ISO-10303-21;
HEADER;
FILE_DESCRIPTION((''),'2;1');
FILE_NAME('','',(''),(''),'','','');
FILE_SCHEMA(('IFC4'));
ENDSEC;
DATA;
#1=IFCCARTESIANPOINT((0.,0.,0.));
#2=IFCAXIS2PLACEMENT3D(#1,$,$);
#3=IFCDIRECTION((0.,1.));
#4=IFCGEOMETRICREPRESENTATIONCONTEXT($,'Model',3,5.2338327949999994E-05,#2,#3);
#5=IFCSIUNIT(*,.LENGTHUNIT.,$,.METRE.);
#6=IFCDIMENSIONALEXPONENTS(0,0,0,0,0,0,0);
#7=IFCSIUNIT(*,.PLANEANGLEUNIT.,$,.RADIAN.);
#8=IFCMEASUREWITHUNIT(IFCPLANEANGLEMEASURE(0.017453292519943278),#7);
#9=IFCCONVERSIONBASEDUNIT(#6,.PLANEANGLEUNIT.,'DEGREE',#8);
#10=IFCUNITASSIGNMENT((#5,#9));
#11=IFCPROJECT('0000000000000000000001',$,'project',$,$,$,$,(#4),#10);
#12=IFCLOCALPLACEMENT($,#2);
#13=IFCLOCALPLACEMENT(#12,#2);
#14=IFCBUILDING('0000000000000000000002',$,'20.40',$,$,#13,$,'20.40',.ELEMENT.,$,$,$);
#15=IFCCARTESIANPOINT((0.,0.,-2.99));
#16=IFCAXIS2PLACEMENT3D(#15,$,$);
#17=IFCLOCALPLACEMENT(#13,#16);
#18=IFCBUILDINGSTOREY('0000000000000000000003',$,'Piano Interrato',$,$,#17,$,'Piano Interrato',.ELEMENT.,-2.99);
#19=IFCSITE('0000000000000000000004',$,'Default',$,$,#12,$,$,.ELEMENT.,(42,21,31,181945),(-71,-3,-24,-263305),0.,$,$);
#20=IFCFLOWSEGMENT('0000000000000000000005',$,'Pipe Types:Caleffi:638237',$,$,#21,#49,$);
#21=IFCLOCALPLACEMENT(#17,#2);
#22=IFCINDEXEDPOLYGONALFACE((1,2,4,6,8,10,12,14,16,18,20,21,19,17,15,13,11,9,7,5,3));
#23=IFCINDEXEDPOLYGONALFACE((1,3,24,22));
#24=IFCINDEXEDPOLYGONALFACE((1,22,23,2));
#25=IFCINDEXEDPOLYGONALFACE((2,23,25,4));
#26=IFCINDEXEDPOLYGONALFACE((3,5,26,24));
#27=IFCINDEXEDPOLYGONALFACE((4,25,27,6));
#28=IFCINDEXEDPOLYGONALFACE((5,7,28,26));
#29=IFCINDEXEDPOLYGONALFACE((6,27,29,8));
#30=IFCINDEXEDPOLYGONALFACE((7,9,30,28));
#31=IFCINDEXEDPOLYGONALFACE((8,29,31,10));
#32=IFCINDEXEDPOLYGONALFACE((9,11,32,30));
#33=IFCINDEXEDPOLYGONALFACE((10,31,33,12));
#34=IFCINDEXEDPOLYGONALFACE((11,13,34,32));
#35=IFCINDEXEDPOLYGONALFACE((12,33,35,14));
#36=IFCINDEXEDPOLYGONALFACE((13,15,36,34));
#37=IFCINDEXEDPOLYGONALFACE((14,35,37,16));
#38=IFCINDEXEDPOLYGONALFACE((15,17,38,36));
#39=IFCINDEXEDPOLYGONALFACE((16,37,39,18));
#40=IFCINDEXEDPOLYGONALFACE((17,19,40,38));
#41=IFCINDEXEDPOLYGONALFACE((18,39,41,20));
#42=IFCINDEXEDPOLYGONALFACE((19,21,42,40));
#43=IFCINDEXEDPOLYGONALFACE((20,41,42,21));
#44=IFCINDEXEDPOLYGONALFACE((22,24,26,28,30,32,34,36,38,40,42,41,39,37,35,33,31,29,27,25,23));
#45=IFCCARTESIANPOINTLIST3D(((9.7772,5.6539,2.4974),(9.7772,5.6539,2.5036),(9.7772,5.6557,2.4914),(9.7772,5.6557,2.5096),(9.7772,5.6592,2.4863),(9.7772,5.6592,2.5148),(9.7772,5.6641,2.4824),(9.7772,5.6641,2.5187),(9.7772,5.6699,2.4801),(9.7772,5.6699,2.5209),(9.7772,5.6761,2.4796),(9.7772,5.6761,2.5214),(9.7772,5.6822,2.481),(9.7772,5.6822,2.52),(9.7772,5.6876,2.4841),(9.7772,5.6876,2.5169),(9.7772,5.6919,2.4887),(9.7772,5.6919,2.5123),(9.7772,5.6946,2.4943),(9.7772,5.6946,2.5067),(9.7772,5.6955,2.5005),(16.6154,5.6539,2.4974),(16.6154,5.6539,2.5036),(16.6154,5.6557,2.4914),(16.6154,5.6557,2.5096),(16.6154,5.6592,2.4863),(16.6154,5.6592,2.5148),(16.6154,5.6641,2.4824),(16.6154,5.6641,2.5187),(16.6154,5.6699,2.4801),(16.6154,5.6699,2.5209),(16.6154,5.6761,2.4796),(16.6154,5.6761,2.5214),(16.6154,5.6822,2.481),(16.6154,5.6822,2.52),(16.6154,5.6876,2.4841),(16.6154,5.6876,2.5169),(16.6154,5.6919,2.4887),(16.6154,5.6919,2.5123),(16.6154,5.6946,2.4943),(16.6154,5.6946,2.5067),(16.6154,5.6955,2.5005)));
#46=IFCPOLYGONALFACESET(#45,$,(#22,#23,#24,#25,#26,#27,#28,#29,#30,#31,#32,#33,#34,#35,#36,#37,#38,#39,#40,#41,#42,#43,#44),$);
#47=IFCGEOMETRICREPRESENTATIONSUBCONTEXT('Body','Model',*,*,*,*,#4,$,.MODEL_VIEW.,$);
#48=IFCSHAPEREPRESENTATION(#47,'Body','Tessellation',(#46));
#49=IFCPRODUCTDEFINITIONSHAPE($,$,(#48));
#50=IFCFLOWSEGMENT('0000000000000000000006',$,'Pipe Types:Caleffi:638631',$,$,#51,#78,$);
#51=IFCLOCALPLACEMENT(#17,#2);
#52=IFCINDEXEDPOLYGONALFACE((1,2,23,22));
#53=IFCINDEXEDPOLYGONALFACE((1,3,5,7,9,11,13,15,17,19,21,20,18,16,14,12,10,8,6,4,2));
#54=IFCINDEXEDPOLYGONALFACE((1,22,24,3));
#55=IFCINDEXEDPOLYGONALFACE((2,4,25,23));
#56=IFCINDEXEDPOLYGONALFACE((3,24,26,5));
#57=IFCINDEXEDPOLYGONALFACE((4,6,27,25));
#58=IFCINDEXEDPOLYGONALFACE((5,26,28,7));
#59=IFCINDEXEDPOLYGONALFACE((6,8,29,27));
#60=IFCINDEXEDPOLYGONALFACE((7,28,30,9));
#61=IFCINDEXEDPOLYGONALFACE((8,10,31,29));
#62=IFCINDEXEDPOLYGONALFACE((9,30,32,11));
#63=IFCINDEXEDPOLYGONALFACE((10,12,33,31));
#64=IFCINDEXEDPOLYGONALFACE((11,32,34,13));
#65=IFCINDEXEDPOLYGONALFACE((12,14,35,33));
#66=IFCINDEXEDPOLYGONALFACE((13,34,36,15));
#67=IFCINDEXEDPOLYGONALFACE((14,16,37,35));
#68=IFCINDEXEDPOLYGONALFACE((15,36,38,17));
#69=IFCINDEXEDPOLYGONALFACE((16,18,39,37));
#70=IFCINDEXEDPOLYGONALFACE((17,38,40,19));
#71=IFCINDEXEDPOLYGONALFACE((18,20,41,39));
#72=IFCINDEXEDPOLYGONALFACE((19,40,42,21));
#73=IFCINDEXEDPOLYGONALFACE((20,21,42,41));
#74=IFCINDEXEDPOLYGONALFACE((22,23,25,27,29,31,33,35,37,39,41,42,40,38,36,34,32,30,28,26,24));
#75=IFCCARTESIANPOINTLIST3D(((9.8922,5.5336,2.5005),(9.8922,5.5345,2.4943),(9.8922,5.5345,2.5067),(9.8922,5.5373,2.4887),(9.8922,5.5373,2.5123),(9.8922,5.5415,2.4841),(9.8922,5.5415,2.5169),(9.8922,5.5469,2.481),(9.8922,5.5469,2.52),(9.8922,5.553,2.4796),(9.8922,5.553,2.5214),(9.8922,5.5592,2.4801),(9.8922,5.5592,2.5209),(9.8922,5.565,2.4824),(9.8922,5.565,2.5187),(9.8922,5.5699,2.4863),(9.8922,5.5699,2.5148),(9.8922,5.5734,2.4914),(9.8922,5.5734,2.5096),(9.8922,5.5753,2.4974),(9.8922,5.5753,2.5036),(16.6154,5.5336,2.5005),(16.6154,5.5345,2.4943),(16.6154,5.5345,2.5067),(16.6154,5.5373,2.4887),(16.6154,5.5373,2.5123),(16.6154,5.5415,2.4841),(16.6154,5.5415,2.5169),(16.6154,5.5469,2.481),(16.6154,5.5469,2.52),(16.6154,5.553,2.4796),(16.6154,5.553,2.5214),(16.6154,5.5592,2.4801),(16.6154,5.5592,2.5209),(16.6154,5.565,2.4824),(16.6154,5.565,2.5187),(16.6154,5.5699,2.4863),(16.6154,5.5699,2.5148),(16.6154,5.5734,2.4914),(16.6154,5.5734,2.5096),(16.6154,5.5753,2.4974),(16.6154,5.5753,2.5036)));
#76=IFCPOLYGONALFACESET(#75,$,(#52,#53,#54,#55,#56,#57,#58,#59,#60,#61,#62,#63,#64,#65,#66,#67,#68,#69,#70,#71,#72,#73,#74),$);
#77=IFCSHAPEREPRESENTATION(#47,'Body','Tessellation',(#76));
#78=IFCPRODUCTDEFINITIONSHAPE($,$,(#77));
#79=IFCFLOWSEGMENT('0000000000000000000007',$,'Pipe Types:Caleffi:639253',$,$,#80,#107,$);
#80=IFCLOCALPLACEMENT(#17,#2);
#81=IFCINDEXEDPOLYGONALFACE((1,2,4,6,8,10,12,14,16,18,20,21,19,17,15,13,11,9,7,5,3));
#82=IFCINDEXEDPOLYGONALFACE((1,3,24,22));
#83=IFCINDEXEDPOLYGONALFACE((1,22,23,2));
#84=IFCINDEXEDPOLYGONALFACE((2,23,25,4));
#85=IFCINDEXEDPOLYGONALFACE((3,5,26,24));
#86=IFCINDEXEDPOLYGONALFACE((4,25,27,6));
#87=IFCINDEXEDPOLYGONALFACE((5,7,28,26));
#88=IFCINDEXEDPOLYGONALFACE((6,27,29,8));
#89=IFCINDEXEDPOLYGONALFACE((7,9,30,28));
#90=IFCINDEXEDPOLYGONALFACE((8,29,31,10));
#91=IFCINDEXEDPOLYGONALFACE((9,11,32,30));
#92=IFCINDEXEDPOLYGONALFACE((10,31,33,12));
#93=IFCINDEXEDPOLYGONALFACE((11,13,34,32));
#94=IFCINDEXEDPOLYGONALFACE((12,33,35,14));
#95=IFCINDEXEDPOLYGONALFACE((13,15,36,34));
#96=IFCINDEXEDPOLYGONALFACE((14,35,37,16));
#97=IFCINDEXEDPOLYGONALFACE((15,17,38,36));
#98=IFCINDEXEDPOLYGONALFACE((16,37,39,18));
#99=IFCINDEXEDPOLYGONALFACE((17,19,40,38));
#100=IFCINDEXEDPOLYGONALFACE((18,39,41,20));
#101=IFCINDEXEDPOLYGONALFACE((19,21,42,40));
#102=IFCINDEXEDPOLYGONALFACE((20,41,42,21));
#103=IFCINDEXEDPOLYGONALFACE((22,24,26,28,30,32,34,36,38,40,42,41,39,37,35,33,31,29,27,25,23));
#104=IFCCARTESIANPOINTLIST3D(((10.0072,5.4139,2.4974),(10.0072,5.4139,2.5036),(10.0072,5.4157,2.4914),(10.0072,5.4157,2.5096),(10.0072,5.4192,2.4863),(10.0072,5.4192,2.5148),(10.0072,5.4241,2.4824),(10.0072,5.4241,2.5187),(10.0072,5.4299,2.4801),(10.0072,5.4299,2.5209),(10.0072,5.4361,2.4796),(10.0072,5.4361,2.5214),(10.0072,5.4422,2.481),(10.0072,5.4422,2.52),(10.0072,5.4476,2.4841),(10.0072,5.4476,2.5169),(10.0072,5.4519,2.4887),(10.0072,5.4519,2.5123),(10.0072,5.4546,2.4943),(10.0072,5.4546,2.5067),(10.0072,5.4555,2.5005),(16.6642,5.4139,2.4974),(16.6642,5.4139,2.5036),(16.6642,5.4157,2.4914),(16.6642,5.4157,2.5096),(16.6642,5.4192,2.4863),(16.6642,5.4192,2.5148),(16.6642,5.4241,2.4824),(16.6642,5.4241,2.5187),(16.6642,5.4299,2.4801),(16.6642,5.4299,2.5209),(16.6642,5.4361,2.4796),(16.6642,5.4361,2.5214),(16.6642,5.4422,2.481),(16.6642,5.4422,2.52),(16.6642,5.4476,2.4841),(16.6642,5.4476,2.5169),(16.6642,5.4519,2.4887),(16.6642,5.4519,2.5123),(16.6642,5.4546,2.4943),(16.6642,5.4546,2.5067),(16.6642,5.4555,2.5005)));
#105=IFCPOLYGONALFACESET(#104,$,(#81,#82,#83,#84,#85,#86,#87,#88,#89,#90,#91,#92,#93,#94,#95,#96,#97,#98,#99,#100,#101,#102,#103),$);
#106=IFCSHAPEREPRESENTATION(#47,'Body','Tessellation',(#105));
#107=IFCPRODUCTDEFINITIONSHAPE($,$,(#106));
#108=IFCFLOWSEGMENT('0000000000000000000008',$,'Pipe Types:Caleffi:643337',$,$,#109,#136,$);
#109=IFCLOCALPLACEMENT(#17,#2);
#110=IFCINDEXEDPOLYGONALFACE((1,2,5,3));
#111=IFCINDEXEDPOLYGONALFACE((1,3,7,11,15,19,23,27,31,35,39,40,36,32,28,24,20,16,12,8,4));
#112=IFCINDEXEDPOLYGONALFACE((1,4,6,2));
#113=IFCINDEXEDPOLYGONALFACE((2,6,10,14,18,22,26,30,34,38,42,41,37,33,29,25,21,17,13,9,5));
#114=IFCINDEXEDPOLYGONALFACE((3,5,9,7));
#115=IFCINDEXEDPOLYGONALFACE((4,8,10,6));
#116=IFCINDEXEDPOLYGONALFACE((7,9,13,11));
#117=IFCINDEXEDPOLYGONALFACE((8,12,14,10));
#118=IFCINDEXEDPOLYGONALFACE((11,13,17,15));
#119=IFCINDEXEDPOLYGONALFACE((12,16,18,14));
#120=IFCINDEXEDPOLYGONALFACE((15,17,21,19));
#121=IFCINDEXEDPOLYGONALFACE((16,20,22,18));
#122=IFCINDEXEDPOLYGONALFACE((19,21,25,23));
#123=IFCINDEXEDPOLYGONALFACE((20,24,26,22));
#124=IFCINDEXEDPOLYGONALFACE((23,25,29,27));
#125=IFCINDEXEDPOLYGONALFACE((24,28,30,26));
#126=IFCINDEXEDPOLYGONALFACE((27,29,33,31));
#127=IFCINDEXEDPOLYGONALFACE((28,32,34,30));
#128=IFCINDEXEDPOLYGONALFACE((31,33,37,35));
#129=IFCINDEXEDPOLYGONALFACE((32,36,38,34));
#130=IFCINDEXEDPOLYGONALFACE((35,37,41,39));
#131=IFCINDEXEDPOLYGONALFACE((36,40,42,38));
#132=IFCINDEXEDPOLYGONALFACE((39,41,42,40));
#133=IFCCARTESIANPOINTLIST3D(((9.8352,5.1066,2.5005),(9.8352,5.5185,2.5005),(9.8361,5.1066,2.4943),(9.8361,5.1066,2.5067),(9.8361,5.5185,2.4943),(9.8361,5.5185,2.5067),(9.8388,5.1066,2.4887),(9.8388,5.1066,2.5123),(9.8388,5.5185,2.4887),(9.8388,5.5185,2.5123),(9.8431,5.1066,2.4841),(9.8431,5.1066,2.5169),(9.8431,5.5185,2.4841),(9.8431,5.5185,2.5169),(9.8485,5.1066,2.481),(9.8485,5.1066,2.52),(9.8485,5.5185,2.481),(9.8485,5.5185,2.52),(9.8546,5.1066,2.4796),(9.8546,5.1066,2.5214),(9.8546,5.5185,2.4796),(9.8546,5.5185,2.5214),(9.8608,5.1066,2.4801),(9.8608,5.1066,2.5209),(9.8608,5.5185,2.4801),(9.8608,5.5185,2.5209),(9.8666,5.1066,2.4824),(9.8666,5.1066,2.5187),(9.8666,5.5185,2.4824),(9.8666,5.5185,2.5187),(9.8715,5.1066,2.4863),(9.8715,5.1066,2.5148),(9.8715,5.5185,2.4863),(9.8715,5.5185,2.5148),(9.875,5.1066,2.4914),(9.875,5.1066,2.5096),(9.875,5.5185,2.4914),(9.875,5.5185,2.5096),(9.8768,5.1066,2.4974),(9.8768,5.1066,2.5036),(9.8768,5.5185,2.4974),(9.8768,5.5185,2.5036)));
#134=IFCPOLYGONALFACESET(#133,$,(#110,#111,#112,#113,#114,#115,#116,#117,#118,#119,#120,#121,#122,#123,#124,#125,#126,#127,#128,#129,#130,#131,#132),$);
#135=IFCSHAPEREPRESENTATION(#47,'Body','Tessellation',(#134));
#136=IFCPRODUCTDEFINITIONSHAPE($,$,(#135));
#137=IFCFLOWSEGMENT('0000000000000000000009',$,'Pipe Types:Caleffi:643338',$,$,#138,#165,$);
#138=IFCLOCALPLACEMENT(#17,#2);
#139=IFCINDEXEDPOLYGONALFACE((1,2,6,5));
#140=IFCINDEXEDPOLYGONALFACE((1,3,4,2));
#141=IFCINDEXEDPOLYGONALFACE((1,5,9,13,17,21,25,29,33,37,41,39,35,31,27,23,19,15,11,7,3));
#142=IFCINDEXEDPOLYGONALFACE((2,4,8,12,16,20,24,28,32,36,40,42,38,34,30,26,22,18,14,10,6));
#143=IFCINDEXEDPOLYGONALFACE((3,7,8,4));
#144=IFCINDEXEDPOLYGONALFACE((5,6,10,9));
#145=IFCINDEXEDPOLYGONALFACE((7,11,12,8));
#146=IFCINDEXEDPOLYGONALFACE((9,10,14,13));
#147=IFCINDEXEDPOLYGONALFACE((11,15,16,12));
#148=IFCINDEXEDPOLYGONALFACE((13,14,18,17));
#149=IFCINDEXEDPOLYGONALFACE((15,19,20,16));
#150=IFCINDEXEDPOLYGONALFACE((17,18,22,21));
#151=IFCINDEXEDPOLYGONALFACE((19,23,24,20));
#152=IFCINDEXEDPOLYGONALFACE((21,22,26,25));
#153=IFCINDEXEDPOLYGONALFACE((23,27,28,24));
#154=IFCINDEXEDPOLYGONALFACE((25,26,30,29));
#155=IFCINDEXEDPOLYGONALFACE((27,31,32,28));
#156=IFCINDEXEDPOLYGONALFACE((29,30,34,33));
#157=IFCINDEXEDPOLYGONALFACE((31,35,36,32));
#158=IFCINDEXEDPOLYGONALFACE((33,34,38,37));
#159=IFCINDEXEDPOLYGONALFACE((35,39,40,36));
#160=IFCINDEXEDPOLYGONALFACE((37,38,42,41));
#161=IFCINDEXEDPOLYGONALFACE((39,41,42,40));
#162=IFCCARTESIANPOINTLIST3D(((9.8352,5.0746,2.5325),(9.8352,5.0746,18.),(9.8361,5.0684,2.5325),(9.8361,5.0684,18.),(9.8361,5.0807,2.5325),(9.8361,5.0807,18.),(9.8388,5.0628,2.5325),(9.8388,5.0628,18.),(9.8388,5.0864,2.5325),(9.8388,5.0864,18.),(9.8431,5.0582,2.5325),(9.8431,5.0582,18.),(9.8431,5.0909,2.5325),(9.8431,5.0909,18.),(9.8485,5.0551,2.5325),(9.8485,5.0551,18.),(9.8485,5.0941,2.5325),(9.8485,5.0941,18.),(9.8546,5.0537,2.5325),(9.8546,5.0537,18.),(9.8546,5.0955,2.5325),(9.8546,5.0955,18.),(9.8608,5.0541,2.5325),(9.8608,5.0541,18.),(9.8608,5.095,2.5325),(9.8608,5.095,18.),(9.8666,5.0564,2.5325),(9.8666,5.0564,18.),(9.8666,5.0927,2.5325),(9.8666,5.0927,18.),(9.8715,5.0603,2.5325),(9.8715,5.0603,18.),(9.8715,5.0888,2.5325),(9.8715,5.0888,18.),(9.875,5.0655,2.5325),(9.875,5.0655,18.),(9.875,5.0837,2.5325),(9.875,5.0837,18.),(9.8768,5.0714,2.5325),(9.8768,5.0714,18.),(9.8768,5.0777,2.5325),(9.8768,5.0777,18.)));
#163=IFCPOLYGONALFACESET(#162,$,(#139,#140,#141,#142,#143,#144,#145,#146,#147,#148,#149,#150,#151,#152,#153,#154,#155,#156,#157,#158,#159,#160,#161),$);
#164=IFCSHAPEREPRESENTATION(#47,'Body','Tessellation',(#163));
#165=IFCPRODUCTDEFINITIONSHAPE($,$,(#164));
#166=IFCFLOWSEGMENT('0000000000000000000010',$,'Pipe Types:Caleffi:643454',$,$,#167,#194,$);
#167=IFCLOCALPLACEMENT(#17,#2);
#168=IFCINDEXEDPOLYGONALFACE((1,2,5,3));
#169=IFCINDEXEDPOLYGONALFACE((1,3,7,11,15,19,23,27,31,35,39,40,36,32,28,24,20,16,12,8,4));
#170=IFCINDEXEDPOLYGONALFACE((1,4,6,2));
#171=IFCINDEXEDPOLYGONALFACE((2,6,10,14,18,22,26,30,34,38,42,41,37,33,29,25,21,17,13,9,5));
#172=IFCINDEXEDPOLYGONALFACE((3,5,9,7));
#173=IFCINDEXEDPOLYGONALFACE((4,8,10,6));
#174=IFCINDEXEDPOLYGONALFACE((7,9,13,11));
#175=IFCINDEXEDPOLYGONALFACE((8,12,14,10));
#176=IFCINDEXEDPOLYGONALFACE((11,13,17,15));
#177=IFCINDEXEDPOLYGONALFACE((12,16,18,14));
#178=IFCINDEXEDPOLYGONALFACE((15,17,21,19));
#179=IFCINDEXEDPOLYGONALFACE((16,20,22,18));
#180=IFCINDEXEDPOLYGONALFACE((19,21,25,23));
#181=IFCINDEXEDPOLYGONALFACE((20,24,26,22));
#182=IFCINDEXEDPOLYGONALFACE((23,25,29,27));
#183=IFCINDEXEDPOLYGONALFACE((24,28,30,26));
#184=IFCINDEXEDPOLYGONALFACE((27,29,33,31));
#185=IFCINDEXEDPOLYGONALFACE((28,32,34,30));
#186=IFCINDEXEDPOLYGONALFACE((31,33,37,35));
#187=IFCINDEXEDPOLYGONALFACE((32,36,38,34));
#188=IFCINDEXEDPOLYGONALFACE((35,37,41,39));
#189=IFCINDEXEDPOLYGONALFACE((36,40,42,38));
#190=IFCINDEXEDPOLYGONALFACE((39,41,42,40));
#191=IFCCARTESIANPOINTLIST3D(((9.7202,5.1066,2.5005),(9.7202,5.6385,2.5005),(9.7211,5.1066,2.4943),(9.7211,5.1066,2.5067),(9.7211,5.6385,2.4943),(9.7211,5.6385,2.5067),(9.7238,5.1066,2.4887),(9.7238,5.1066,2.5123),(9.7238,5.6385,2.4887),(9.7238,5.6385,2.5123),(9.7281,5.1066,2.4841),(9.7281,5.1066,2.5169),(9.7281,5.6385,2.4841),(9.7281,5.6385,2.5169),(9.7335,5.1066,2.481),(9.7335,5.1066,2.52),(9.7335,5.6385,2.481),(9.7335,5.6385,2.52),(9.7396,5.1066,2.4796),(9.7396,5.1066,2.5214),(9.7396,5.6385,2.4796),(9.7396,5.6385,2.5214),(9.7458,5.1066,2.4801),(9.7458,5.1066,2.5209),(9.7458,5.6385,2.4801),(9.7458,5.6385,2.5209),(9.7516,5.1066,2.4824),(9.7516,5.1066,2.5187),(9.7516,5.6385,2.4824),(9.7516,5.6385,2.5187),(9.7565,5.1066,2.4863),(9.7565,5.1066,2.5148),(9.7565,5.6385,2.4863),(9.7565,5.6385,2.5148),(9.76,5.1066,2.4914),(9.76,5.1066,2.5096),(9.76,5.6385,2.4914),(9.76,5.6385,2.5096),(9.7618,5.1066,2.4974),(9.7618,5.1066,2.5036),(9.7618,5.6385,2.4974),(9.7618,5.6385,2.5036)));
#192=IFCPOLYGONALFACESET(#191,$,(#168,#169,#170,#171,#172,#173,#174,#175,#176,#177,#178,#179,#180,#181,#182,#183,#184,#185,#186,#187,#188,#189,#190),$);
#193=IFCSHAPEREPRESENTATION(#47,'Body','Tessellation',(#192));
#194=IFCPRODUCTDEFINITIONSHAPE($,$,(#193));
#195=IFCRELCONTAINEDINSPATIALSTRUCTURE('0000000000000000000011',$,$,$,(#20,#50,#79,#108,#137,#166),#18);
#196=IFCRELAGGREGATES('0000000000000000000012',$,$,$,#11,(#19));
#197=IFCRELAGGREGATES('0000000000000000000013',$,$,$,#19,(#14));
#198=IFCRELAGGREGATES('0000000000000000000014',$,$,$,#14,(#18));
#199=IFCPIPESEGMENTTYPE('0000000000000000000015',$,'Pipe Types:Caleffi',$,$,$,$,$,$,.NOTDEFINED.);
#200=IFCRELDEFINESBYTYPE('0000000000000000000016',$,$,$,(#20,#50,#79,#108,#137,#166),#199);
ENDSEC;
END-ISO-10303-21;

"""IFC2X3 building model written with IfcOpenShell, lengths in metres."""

from ifc_helpers import new_model, entity, si_unit, converted_unit, direction, frame, frame_2d, origin, origin_2d_with_axis, place, context, subcontext, project, spatial, circle, extrude, type_object, element, save


model = new_model("IFC2X3")

# Units and contexts
model_context = context("Model", 3, precision=5.2338327949999994e-05, world=origin(), true_north=direction((0.0, 1.0)))
body_context = subcontext(model_context, "Body", "Model", "MODEL_VIEW")
ifc_project = project(units=[si_unit("LENGTHUNIT", "METRE"), converted_unit("PLANEANGLEUNIT", "DEGREE", entity("IfcPlaneAngleMeasure", 0.017453292519943278), si_unit("PLANEANGLEUNIT", "RADIAN"), dimensions=[0, 0, 0, 0, 0, 0, 0])], contexts=[model_context])

# Site, building, storey
site_placement = place(None, origin())
site = spatial("IfcSite", under=ifc_project, at=site_placement, Name="Default", CompositionType="ELEMENT", RefLatitude=(42, 21, 31, 181945), RefLongitude=(-71, -3, -24, -263305), RefElevation=0.0)
building_placement = place(site_placement, origin())
building = spatial("IfcBuilding", under=site, at=building_placement, Name="20.40", LongName="20.40", CompositionType="ELEMENT")
storey_placement = place(building_placement, frame((0.0, 0.0, -2.99)))
storey = spatial("IfcBuildingStorey", under=building, at=storey_placement, Name="Piano Interrato", LongName="Piano Interrato", CompositionType="ELEMENT", Elevation=-2.99)

# Flow segments
pipe_segment_type = type_object("IfcPipeSegmentType", Name="Pipe Types:Caleffi", PredefinedType="NOTDEFINED")
flow_segment_1_placement = place(storey_placement, origin())
element("IfcFlowSegment", 1, at=flow_segment_1_placement, inside=storey, type_object=pipe_segment_type, Name="Pipe Types:Caleffi:638237", context=body_context, shape_type="SweptSolid", body=[
    extrude(circle(Radius=0.0209, at=frame_2d((0.0, 0.0), x_axis=(1.0, 0.0))), frame((9.7772, 5.6746, 2.5005), z_axis=(1.0, 0.0, 0.0), x_axis=(0.0, 1.0, 0.0)), (0.0, 0.0, 1.0), 6.8381),
])
flow_segment_2_placement = place(storey_placement, origin())
element("IfcFlowSegment", 2, at=flow_segment_2_placement, inside=storey, type_object=pipe_segment_type, Name="Pipe Types:Caleffi:638631", context=body_context, shape_type="SweptSolid", body=[
    extrude(circle(Radius=0.0209, at=origin_2d_with_axis()), frame((9.8922, 5.5546, 2.5005), z_axis=(1.0, 0.0, 0.0), x_axis=(0.0, -1.0, 0.0)), (0.0, 0.0, 1.0), 6.7231),
])
flow_segment_3_placement = place(storey_placement, origin())
element("IfcFlowSegment", 3, at=flow_segment_3_placement, inside=storey, type_object=pipe_segment_type, Name="Pipe Types:Caleffi:639253", context=body_context, shape_type="SweptSolid", body=[
    extrude(circle(Radius=0.0209, at=frame_2d((0.0, 0.0), x_axis=(1.0, 0.0))), frame((10.0072, 5.4346, 2.5005), z_axis=(1.0, 0.0, 0.0), x_axis=(0.0, 1.0, 0.0)), (0.0, 0.0, 1.0), 6.6569),
])
flow_segment_4_placement = place(storey_placement, origin())
element("IfcFlowSegment", 4, at=flow_segment_4_placement, inside=storey, type_object=pipe_segment_type, Name="Pipe Types:Caleffi:643337", context=body_context, shape_type="SweptSolid", body=[
    extrude(circle(Radius=0.0209, at=frame_2d((0.0, 0.0), x_axis=(1.0, 0.0))), frame((9.8561, 5.1066, 2.5005), z_axis=(0.0, 1.0, 0.0), x_axis=(-1.0, 0.0, 0.0)), (0.0, 0.0, 1.0), 0.4119),
])
flow_segment_5_placement = place(storey_placement, origin())
element("IfcFlowSegment", 5, at=flow_segment_5_placement, inside=storey, type_object=pipe_segment_type, Name="Pipe Types:Caleffi:643338", context=body_context, shape_type="SweptSolid", body=[
    extrude(circle(Radius=0.0209, at=origin_2d_with_axis()), frame((9.8561, 5.0746, 2.5325), z_axis=(0.0, 0.0, 1.0), x_axis=(-1.0, 0.0, 0.0)), (0.0, 0.0, 1.0), 15.4675),
])
flow_segment_6_placement = place(storey_placement, origin())
element("IfcFlowSegment", 6, at=flow_segment_6_placement, inside=storey, type_object=pipe_segment_type, Name="Pipe Types:Caleffi:643454", context=body_context, shape_type="SweptSolid", body=[
    extrude(circle(Radius=0.0209, at=frame_2d((0.0, 0.0), x_axis=(1.0, 0.0))), frame((9.7411, 5.1066, 2.5005), z_axis=(0.0, 1.0, 0.0), x_axis=(-1.0, 0.0, 0.0)), (0.0, 0.0, 1.0), 0.5319),
])

save(model, "model.ifc")
